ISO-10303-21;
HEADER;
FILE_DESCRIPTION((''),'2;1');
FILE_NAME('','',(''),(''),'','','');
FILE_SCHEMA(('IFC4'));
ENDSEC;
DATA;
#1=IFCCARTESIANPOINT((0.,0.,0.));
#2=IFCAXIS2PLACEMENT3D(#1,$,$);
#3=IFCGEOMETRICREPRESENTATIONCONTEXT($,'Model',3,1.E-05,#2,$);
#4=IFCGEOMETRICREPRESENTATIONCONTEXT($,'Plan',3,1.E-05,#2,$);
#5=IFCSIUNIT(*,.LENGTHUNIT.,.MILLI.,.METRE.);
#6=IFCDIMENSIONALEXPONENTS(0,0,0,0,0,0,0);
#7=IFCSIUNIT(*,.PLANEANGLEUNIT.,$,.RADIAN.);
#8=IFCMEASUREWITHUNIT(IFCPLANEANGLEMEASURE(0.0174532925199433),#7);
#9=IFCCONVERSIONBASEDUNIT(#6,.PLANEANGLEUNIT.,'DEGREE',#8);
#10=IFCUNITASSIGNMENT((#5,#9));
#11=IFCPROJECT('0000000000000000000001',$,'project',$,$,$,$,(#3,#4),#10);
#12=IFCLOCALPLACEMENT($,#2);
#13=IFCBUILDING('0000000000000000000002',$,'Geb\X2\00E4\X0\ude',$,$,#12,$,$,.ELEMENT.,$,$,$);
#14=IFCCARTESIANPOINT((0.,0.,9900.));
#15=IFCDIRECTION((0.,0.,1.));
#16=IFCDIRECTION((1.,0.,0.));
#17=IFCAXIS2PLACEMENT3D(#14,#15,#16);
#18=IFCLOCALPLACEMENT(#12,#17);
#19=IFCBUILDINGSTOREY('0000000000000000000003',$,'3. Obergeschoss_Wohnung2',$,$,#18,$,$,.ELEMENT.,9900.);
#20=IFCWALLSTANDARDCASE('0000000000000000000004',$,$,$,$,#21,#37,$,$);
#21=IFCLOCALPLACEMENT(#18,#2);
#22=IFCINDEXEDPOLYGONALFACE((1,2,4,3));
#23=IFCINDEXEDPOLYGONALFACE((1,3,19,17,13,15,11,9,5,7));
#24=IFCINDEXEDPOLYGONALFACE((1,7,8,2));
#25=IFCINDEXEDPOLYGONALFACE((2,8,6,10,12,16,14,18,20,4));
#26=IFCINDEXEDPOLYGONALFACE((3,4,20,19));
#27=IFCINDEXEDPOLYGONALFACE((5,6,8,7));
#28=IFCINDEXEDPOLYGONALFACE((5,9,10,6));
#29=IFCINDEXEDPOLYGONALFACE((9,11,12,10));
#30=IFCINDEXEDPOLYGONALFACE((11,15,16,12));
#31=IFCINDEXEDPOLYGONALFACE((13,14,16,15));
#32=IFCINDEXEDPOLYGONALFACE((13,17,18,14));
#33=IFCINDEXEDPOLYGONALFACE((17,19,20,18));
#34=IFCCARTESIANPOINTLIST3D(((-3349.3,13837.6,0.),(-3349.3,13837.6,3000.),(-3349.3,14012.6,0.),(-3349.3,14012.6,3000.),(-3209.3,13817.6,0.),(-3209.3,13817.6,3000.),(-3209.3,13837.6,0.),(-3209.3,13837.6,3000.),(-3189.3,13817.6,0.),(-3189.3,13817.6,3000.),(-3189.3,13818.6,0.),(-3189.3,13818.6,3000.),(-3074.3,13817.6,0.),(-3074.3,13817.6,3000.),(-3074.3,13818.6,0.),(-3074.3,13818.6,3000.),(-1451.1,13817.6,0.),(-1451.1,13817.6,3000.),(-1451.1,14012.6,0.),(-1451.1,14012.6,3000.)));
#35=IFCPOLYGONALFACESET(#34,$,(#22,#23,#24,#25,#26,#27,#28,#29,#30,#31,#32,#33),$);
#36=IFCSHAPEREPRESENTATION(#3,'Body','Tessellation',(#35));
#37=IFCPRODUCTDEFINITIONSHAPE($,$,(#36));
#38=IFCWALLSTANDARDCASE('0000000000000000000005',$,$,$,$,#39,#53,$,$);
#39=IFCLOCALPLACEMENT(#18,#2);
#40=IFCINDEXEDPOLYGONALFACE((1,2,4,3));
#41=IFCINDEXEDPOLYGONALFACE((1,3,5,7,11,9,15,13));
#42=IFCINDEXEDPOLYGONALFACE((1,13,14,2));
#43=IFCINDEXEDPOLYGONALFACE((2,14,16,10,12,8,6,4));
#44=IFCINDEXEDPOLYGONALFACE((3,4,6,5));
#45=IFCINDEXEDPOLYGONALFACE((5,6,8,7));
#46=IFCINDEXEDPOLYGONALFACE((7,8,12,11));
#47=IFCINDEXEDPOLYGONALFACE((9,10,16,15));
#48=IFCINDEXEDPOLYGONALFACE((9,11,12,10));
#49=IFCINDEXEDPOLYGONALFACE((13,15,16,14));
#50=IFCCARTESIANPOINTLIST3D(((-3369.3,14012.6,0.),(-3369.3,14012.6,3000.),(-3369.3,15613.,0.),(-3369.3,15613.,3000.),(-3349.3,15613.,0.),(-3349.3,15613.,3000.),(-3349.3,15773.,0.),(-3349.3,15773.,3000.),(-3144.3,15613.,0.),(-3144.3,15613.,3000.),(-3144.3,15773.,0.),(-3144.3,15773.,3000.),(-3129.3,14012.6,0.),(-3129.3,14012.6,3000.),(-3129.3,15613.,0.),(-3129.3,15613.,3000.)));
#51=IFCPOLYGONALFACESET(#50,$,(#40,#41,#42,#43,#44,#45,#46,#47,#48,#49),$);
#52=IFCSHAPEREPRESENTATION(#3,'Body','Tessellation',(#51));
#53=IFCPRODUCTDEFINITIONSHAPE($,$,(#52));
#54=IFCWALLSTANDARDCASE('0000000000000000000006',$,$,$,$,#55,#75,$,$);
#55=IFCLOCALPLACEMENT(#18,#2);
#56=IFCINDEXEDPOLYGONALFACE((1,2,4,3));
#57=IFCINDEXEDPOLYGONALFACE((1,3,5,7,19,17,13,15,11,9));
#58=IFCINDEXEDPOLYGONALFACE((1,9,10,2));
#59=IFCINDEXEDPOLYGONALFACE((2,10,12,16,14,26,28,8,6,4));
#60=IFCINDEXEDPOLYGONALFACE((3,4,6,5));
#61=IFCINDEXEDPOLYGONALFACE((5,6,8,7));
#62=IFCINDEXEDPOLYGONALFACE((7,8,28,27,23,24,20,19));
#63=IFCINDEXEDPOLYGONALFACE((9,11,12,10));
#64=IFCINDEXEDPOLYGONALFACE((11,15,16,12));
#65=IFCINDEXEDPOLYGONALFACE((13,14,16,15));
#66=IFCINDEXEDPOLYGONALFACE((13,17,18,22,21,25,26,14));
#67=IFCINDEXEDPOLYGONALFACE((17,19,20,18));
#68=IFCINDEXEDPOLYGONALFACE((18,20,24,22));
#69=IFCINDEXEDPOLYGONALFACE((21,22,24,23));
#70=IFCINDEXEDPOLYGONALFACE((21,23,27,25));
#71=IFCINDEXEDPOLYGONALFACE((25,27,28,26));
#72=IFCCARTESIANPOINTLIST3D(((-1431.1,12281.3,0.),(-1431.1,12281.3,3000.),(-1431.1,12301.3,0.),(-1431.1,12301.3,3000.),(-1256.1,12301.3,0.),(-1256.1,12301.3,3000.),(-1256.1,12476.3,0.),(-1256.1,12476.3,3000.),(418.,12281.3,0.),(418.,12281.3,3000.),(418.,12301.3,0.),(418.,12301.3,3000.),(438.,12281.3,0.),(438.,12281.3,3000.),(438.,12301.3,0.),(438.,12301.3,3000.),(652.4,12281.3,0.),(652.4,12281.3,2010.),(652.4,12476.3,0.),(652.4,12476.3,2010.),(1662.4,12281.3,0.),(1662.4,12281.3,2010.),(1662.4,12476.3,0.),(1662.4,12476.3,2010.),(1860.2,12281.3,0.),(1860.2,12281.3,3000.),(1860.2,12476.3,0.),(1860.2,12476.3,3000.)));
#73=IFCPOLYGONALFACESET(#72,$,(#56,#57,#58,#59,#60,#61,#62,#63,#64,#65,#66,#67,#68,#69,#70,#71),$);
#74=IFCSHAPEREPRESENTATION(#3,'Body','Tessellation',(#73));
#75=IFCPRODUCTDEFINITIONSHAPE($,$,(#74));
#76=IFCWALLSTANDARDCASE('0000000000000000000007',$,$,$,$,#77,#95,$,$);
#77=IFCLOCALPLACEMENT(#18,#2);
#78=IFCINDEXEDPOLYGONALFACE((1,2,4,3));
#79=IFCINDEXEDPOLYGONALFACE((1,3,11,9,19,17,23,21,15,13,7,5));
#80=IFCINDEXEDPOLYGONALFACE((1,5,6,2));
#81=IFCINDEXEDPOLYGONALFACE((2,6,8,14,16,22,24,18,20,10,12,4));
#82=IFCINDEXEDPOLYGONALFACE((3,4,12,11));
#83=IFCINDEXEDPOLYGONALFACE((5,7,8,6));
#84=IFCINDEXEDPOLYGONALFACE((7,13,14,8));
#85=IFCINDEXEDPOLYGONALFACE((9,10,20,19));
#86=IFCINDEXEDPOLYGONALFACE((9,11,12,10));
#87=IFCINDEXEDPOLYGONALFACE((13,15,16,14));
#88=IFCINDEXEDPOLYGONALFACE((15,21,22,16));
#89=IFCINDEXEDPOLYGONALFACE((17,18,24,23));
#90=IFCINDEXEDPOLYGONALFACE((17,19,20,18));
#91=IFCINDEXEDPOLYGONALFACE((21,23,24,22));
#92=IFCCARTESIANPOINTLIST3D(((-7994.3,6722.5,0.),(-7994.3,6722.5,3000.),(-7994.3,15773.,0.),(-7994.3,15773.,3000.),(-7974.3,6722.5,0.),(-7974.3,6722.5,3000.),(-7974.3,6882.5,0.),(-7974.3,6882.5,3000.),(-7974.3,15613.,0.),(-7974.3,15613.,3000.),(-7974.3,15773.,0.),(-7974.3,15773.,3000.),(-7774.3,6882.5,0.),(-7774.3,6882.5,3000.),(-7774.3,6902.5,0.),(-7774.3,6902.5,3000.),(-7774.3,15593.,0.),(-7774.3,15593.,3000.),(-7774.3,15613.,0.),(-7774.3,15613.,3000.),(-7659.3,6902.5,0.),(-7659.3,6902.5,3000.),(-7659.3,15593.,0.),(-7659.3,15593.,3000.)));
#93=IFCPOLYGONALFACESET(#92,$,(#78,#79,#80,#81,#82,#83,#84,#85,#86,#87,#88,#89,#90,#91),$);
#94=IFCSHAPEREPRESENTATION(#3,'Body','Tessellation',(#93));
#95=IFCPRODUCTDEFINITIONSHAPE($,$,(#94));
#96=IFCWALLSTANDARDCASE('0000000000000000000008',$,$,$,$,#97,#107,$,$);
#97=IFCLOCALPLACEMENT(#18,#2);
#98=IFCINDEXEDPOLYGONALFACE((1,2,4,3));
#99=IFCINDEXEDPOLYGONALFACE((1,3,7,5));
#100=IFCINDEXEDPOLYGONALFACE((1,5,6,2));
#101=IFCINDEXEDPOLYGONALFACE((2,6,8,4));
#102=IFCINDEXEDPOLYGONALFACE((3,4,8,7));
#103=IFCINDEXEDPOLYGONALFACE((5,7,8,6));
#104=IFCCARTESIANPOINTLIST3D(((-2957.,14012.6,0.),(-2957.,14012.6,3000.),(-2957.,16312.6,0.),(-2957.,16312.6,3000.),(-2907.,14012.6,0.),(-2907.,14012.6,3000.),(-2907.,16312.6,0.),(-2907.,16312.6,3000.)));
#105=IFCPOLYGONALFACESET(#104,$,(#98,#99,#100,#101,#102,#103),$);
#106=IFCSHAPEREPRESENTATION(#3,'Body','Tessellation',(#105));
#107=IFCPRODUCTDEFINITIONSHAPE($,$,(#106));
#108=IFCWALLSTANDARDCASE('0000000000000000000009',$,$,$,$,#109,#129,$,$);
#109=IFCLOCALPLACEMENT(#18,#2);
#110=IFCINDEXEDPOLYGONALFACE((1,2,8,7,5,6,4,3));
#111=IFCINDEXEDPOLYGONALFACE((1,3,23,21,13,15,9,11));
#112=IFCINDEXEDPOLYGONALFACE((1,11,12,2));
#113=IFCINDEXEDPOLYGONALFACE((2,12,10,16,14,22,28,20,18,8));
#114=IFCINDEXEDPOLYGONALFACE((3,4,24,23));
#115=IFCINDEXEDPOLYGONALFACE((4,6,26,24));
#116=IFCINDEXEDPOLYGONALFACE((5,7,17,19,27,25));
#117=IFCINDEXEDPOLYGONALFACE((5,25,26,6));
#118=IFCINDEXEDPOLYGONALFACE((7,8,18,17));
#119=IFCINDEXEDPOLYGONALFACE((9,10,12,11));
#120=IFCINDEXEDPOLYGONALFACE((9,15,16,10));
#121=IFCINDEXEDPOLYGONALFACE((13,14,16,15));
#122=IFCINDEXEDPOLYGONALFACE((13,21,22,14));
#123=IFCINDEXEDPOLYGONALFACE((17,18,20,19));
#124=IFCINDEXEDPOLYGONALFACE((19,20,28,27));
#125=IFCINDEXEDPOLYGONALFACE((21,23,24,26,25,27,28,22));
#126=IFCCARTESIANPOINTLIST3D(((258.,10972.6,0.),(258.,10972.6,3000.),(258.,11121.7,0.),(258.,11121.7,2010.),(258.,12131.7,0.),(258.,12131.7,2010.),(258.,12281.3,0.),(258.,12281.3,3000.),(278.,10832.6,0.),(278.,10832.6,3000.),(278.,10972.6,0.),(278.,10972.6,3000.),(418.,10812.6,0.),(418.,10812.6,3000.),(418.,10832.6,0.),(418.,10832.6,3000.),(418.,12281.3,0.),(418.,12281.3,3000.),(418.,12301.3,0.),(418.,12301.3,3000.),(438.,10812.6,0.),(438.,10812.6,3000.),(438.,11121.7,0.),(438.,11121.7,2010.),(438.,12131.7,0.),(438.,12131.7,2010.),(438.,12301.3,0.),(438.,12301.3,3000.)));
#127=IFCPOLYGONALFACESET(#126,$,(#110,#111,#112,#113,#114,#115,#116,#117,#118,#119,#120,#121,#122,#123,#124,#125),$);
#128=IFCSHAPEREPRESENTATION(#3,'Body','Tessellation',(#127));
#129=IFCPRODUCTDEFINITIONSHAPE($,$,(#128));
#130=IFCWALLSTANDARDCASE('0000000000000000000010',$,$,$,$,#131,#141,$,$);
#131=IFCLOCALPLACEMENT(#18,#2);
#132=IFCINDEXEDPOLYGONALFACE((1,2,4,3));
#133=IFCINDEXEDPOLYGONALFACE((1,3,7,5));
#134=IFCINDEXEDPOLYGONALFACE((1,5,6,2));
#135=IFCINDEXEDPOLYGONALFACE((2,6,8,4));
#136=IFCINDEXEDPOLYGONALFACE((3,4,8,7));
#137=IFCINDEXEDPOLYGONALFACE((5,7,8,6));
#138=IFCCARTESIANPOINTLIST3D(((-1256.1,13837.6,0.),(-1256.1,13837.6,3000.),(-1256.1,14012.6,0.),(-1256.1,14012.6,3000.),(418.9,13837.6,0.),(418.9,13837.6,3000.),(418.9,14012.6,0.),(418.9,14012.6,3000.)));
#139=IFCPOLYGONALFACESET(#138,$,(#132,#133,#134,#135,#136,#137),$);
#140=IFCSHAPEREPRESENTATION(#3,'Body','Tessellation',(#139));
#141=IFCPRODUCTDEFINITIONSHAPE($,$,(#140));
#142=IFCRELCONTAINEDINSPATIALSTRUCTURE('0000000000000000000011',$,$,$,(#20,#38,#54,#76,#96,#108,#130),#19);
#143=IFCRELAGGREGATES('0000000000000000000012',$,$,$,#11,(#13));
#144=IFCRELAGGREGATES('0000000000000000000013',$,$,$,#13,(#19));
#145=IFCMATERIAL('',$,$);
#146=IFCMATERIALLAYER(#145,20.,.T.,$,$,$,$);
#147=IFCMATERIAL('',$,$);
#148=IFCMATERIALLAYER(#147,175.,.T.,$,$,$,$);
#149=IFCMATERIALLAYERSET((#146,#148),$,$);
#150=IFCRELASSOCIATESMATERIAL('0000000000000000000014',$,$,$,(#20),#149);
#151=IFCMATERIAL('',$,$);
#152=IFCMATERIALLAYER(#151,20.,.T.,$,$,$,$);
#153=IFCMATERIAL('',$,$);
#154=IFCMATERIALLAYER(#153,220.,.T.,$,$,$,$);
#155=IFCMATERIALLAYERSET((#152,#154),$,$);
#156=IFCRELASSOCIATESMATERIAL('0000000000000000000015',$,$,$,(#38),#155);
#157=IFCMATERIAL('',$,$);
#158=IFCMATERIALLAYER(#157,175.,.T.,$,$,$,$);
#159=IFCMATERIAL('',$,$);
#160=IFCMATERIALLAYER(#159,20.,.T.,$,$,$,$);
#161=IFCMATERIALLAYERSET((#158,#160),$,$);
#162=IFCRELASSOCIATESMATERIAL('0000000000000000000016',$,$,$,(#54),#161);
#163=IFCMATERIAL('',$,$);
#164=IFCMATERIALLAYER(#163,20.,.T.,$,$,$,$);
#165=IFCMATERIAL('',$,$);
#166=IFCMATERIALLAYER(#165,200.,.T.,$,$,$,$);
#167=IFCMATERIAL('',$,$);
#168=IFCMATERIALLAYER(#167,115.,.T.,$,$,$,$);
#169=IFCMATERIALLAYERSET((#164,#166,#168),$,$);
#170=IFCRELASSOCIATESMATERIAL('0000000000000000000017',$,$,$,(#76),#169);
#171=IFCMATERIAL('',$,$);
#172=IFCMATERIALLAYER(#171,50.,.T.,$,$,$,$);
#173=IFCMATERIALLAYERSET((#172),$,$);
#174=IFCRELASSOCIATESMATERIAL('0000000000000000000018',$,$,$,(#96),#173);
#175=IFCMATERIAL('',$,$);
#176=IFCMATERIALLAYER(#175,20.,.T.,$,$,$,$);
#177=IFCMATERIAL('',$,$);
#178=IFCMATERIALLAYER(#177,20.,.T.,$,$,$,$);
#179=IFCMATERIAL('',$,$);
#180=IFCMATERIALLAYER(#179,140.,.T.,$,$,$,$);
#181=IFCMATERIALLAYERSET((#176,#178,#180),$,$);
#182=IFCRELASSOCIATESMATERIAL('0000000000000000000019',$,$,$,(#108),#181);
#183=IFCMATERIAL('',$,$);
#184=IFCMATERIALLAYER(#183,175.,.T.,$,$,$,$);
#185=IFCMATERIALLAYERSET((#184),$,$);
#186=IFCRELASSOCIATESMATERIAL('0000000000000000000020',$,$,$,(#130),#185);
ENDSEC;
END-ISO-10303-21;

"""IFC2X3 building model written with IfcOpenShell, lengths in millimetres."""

from ifc_helpers import new_model, entity, si_unit, converted_unit, frame, frame_2d, origin, origin_with_axes, place, context, project, spatial, polyline, rectangle, outline, extrude, material, layer, layer_set, layer_usage, element, save


model = new_model("IFC2X3")

# Units and contexts
model_context = context("Model", 3, precision=1e-05, world=origin())
plan_context = context("Plan", 3, precision=1e-05, world=origin())
ifc_project = project(units=[si_unit("LENGTHUNIT", "METRE", prefix="MILLI"), converted_unit("PLANEANGLEUNIT", "DEGREE", entity("IfcPlaneAngleMeasure", 0.0174532925199433), si_unit("PLANEANGLEUNIT", "RADIAN"), dimensions=[0, 0, 0, 0, 0, 0, 0])], contexts=[model_context, plan_context])

# Building, storey
building_placement = place(None, origin())
building = spatial("IfcBuilding", under=ifc_project, at=building_placement, Name="Gebäude", CompositionType="ELEMENT")
storey_placement = place(building_placement, frame((0.0, 0.0, 9900.0), z_axis=(0.0, 0.0, 1.0), x_axis=(1.0, 0.0, 0.0)))
storey = spatial("IfcBuildingStorey", under=building, at=storey_placement, Name="3. Obergeschoss_Wohnung2", CompositionType="ELEMENT", Elevation=9900.0)

# Walls
ifc_material_1 = material(Name="")
ifc_layer_1 = layer(ifc_material_1, 20.0, ventilated=True)
ifc_material_2 = material(Name="")
ifc_layer_2 = layer(ifc_material_2, 175.0, ventilated=True)
ifc_layer_set_1 = layer_set([ifc_layer_1, ifc_layer_2])
ifc_layer_usage_1 = layer_usage(ifc_layer_set_1, "AXIS2", "POSITIVE", -195.0)
wall_1_placement = place(storey_placement, frame((-3209.3, 13817.6, 0.0), z_axis=(0.0, 0.0, 1.0), x_axis=(1.0, 0.0, 0.0)))
element("IfcWallStandardCase", 1, at=wall_1_placement, inside=storey, material=ifc_layer_usage_1, context=model_context, shape_type="SweptSolid", body=[
    extrude(outline(polyline([(-140.0, 195.0), (-140.0, 20.0), (0.0, 20.0), (0.0, 0.0), (20.0, 0.0), (20.0, 1.0), (135.0, 1.0), (135.0, 0.0), (1758.2, 0.0), (1758.2, 195.0), (-140.0, 195.0)])), origin_with_axes(), (0.0, 0.0, 1.0), 3000.0),
])
ifc_material_3 = material(Name="")
ifc_layer_3 = layer(ifc_material_3, 20.0, ventilated=True)
ifc_material_4 = material(Name="")
ifc_layer_4 = layer(ifc_material_4, 220.0, ventilated=True)
ifc_layer_set_2 = layer_set([ifc_layer_3, ifc_layer_4])
ifc_layer_usage_2 = layer_usage(ifc_layer_set_2, "AXIS2", "POSITIVE", 0.0)
wall_2_placement = place(storey_placement, frame((-3369.3, 15613.0, 0.0), z_axis=(0.0, 0.0, 1.0), x_axis=(0.0, -1.0, 0.0)))
element("IfcWallStandardCase", 2, at=wall_2_placement, inside=storey, material=ifc_layer_usage_2, context=model_context, shape_type="SweptSolid", body=[
    extrude(outline(polyline([(-160.0, 225.0), (-160.0, 20.0), (0.0, 20.0), (0.0, 0.0), (1600.4, 0.0), (1600.4, 240.0), (0.0, 240.0), (0.0, 225.0), (-160.0, 225.0)])), origin_with_axes(), (0.0, 0.0, 1.0), 3000.0),
])

# Wall, opening
ifc_material_5 = material(Name="")
ifc_layer_5 = layer(ifc_material_5, 175.0, ventilated=True)
ifc_material_6 = material(Name="")
ifc_layer_6 = layer(ifc_material_6, 20.0, ventilated=True)
ifc_layer_set_3 = layer_set([ifc_layer_5, ifc_layer_6])
ifc_layer_usage_3 = layer_usage(ifc_layer_set_3, "AXIS2", "POSITIVE", -195.0)
wall_3_placement = place(storey_placement, frame((-1431.1, 12281.3, 0.0), z_axis=(0.0, 0.0, 1.0), x_axis=(1.0, 0.0, 0.0)))
wall_3 = element("IfcWallStandardCase", 3, at=wall_3_placement, inside=storey, material=ifc_layer_usage_3, context=model_context, shape_type="SweptSolid", body=[
    extrude(outline(polyline([(175.0, 195.0), (175.0, 20.0), (0.0, 20.0), (0.0, 0.0), (1849.0, 0.0), (1849.0, 20.0), (1869.0, 20.0), (1869.0, 0.0), (3291.3, 0.0), (3291.3, 195.0), (175.0, 195.0)])), origin_with_axes(), (0.0, 0.0, 1.0), 3000.0),
])
opening_1_placement = place(wall_3_placement, frame((2083.4, 0.0, 0.0), z_axis=(0.0, 1.0, 0.0), x_axis=(0.0, 0.0, 1.0)))
element("IfcOpeningElement", 4, at=opening_1_placement, cuts=wall_3, ObjectType="Opening", context=model_context, shape_type="SweptSolid", body=[
    extrude(rectangle(XDim=2010.0, YDim=1010.0, at=frame_2d((1005.0, 505.0), x_axis=(1.0, 0.0))), origin_with_axes(), (0.0, 0.0, 1.0), 195.0),
])

# Walls
ifc_material_7 = material(Name="")
ifc_layer_7 = layer(ifc_material_7, 20.0, ventilated=True)
ifc_material_8 = material(Name="")
ifc_layer_8 = layer(ifc_material_8, 200.0, ventilated=True)
ifc_material_9 = material(Name="")
ifc_layer_9 = layer(ifc_material_9, 115.0, ventilated=True)
ifc_layer_set_4 = layer_set([ifc_layer_7, ifc_layer_8, ifc_layer_9])
ifc_layer_usage_4 = layer_usage(ifc_layer_set_4, "AXIS2", "POSITIVE", 0.0)
wall_4_placement = place(storey_placement, frame((-7994.3, 15773.0, 0.0), z_axis=(0.0, 0.0, 1.0), x_axis=(0.0, -1.0, 0.0)))
element("IfcWallStandardCase", 5, at=wall_4_placement, inside=storey, material=ifc_layer_usage_4, context=model_context, shape_type="SweptSolid", body=[
    extrude(outline(polyline([(0.0, 0.0), (9050.5, 0.0), (9050.5, 20.0), (8890.5, 20.0), (8890.5, 220.0), (8870.5, 220.0), (8870.5, 335.0), (180.0, 335.0), (180.0, 220.0), (160.0, 220.0), (160.0, 20.0), (0.0, 20.0), (0.0, 0.0)])), origin_with_axes(), (0.0, 0.0, 1.0), 3000.0),
])
ifc_material_10 = material(Name="")
ifc_layer_10 = layer(ifc_material_10, 50.0, ventilated=True)
ifc_layer_set_5 = layer_set([ifc_layer_10])
ifc_layer_usage_5 = layer_usage(ifc_layer_set_5, "AXIS2", "POSITIVE", 0.0)
wall_5_placement = place(storey_placement, frame((-2957.0, 16312.6, 0.0), z_axis=(0.0, 0.0, 1.0), x_axis=(0.0, -1.0, 0.0)))
element("IfcWallStandardCase", 6, at=wall_5_placement, inside=storey, material=ifc_layer_usage_5, context=model_context, shape_type="SweptSolid", body=[
    extrude(rectangle(XDim=2300.0, YDim=50.0, at=frame_2d((1150.0, 25.0), x_axis=(1.0, 0.0))), origin_with_axes(), (0.0, 0.0, 1.0), 3000.0),
])

# Wall, opening
ifc_material_11 = material(Name="")
ifc_layer_11 = layer(ifc_material_11, 20.0, ventilated=True)
ifc_material_12 = material(Name="")
ifc_layer_12 = layer(ifc_material_12, 20.0, ventilated=True)
ifc_material_13 = material(Name="")
ifc_layer_13 = layer(ifc_material_13, 140.0, ventilated=True)
ifc_layer_set_6 = layer_set([ifc_layer_11, ifc_layer_12, ifc_layer_13])
ifc_layer_usage_6 = layer_usage(ifc_layer_set_6, "AXIS2", "POSITIVE", 0.0)
wall_6_placement = place(storey_placement, frame((438.0, 10812.6, 0.0), z_axis=(0.0, 0.0, 1.0), x_axis=(0.0, 1.0, 0.0)))
wall_6 = element("IfcWallStandardCase", 7, at=wall_6_placement, inside=storey, material=ifc_layer_usage_6, context=model_context, shape_type="SweptSolid", body=[
    extrude(outline(polyline([(160.0, 180.0), (160.0, 160.0), (20.0, 160.0), (20.0, 20.0), (0.0, 20.0), (0.0, 0.0), (1488.6, 0.0), (1488.6, 20.0), (1468.6, 20.0), (1468.6, 180.0), (160.0, 180.0)])), origin_with_axes(), (0.0, 0.0, 1.0), 3000.0),
])
opening_2_placement = place(wall_6_placement, frame((309.1, 0.0, 0.0), z_axis=(0.0, 1.0, 0.0), x_axis=(0.0, 0.0, 1.0)))
element("IfcOpeningElement", 8, at=opening_2_placement, cuts=wall_6, ObjectType="Opening", context=model_context, shape_type="SweptSolid", body=[
    extrude(rectangle(XDim=2010.0, YDim=1010.0, at=frame_2d((1005.0, 505.0), x_axis=(1.0, 0.0))), origin_with_axes(), (0.0, 0.0, 1.0), 180.0),
])

# Wall
ifc_material_14 = material(Name="")
ifc_layer_14 = layer(ifc_material_14, 175.0, ventilated=True)
ifc_layer_set_7 = layer_set([ifc_layer_14])
ifc_layer_usage_7 = layer_usage(ifc_layer_set_7, "AXIS2", "POSITIVE", 0.0)
wall_7_placement = place(storey_placement, frame((418.9, 14012.6, 0.0), z_axis=(0.0, 0.0, 1.0), x_axis=(-1.0, 0.0, 0.0)))
element("IfcWallStandardCase", 9, at=wall_7_placement, inside=storey, material=ifc_layer_usage_7, context=model_context, shape_type="SweptSolid", body=[
    extrude(rectangle(XDim=1675.0, YDim=175.0, at=frame_2d((837.5, 87.5), x_axis=(1.0, 0.0))), origin_with_axes(), (0.0, 0.0, 1.0), 3000.0),
])

save(model, "model.ifc")
